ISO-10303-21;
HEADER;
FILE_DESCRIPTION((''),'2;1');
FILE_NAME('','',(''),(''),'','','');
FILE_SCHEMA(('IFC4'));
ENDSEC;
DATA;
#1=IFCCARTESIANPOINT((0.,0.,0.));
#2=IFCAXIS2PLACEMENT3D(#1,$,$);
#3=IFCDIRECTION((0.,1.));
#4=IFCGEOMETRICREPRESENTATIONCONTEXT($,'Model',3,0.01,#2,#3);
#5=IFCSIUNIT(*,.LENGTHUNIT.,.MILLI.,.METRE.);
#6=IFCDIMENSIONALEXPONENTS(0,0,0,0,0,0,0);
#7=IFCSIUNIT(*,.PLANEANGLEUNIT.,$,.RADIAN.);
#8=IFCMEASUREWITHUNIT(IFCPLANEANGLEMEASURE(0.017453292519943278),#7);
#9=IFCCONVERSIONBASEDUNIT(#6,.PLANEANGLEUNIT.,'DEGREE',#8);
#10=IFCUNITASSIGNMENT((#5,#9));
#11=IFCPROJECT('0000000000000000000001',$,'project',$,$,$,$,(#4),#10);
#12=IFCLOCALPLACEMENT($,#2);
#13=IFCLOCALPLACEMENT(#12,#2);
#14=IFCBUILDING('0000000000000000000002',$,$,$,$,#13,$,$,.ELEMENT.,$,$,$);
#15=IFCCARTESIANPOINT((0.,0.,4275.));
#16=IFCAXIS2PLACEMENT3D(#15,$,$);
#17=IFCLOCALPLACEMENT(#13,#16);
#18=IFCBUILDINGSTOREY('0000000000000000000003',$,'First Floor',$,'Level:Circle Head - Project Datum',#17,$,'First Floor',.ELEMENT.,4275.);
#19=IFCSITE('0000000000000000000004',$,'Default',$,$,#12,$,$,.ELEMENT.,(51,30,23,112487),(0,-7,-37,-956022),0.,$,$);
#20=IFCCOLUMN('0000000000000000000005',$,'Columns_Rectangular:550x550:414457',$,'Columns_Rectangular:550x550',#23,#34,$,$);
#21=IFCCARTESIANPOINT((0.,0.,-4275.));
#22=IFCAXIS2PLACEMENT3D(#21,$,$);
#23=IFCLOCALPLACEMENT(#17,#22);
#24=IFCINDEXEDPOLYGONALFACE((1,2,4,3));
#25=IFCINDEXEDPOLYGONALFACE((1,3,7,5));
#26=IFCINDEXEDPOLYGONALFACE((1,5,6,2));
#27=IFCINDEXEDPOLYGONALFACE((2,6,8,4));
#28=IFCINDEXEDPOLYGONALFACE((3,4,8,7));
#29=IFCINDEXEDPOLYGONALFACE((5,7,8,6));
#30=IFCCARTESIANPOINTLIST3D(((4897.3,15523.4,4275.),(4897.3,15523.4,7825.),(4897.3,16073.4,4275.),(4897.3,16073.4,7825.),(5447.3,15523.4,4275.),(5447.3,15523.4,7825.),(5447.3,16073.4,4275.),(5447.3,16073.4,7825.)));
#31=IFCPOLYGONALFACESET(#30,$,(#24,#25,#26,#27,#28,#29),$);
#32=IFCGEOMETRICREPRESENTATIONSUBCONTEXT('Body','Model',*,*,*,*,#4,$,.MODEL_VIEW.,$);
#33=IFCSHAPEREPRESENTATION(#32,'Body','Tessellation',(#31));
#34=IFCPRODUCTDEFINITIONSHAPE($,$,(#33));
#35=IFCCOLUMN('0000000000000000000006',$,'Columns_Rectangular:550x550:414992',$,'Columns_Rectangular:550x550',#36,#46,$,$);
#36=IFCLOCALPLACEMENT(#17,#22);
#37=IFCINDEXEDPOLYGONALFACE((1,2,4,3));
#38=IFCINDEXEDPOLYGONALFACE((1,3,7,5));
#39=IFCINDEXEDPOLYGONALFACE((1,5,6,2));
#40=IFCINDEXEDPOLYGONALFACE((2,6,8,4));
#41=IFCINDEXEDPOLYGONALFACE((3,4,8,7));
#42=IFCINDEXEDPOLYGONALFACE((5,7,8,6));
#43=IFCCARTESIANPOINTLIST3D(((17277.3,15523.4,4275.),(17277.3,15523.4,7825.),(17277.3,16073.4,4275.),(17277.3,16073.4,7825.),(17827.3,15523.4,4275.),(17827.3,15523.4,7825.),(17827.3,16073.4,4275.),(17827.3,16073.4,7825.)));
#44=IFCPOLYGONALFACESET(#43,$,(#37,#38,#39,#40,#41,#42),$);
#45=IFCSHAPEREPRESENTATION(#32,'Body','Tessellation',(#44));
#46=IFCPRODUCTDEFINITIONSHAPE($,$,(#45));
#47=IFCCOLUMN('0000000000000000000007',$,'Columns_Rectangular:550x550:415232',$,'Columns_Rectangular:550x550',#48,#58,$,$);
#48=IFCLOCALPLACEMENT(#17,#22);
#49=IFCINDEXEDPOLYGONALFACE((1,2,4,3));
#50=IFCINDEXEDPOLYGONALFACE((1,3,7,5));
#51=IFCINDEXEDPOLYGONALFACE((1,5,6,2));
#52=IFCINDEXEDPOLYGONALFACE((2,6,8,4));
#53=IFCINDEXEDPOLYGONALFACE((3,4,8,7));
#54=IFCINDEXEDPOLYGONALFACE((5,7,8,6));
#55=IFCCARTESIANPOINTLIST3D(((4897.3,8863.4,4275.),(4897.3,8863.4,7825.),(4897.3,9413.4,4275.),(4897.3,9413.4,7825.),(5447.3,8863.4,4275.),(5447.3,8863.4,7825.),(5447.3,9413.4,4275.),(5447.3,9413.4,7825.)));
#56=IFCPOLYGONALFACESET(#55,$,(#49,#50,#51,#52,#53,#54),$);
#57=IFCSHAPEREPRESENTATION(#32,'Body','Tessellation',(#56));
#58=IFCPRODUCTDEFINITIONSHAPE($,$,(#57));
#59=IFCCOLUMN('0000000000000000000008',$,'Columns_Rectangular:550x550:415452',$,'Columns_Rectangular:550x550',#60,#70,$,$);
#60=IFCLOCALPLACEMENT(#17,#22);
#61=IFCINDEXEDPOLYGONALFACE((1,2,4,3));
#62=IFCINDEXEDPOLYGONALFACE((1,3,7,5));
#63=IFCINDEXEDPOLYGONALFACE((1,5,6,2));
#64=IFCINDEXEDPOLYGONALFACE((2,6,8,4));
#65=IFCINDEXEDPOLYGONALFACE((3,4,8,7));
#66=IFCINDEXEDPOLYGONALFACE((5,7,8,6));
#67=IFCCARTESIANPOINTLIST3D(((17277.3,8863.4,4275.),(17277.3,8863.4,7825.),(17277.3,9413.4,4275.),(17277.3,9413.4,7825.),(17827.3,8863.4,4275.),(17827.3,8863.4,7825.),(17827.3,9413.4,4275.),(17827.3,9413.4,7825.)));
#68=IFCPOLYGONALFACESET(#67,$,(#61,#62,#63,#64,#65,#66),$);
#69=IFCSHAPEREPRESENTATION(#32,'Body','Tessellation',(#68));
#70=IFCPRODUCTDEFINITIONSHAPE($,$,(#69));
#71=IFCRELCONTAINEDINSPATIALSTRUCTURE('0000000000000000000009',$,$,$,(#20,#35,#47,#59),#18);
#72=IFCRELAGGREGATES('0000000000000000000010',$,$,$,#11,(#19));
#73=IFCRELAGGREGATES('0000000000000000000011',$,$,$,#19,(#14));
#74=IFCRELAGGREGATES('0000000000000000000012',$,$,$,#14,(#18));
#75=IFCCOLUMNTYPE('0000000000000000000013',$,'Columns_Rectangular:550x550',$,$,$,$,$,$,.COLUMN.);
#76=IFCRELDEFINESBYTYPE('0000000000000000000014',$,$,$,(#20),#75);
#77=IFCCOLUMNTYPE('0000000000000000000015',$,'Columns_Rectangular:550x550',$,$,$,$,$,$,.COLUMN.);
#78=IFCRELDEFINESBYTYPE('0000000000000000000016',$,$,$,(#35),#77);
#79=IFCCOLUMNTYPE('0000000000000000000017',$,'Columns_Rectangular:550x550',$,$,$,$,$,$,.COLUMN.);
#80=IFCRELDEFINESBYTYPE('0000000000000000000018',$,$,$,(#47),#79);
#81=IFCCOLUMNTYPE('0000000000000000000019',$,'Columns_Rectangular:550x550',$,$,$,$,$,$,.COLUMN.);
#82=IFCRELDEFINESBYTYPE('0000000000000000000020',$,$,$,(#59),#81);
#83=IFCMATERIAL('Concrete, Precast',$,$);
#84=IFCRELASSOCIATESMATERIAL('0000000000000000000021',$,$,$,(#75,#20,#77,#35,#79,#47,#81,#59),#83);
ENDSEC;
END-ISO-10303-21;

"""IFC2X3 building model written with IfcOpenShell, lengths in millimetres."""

from ifc_helpers import new_model, entity, si_unit, converted_unit, direction, frame, frame_2d, origin, place, context, subcontext, project, spatial, rectangle, extrude, source, transform, mapped, material, type_object, type_shapes, element, save


model = new_model("IFC2X3")

# Units and contexts
model_context = context("Model", 3, precision=0.01, world=origin(), true_north=direction((0.0, 1.0)))
body_context = subcontext(model_context, "Body", "Model", "MODEL_VIEW")
ifc_project = project(units=[si_unit("LENGTHUNIT", "METRE", prefix="MILLI"), converted_unit("PLANEANGLEUNIT", "DEGREE", entity("IfcPlaneAngleMeasure", 0.017453292519943278), si_unit("PLANEANGLEUNIT", "RADIAN"), dimensions=[0, 0, 0, 0, 0, 0, 0])], contexts=[model_context])

# Site, building, storey
site_placement = place(None, origin())
site = spatial("IfcSite", under=ifc_project, at=site_placement, Name="Default", CompositionType="ELEMENT", RefLatitude=(51, 30, 23, 112487), RefLongitude=(0, -7, -37, -956022), RefElevation=0.0)
building_placement = place(site_placement, origin())
building = spatial("IfcBuilding", under=site, at=building_placement, CompositionType="ELEMENT")
storey_placement = place(building_placement, frame((0.0, 0.0, 4275.0)))
storey = spatial("IfcBuildingStorey", under=building, at=storey_placement, Name="First Floor", ObjectType="Level:Circle Head - Project Datum", LongName="First Floor", CompositionType="ELEMENT", Elevation=4275.0)

# Columns
ifc_material_1 = material(Name="Concrete, Precast")
column_type_1 = type_object("IfcColumnType", Name="Columns_Rectangular:550x550", PredefinedType="COLUMN", material=ifc_material_1)
shared_shape_1 = source(origin(), body_context, "Body", "SweptSolid", [
    extrude(rectangle(XDim=550.0, YDim=550.0, at=frame_2d((0.0, 0.0), x_axis=(1.0, 0.0))), frame((5172.3, 15798.4, 4275.0), z_axis=(0.0, 0.0, 1.0), x_axis=(-1.0, 0.0, 0.0)), (0.0, 0.0, 1.0), 3550.0),
])
type_shapes(column_type_1, [shared_shape_1])
column_1_placement = place(storey_placement, frame((0.0, 0.0, -4275.0)))
element("IfcColumn", 1, at=column_1_placement, inside=storey, type_object=column_type_1, material=ifc_material_1, Name="Columns_Rectangular:550x550:414457", ObjectType="Columns_Rectangular:550x550", context=body_context, shape_type="MappedRepresentation", body=[
    mapped(shared_shape_1, transform((0.0, 0.0, 0.0), scale=1.0)),
])
column_type_2 = type_object("IfcColumnType", Name="Columns_Rectangular:550x550", PredefinedType="COLUMN", material=ifc_material_1)
shared_shape_2 = source(origin(), body_context, "Body", "SweptSolid", [
    extrude(rectangle(XDim=550.0, YDim=550.0, at=frame_2d((0.0, 0.0), x_axis=(1.0, 0.0))), frame((17552.3, 15798.4, 4275.0), z_axis=(0.0, 0.0, 1.0), x_axis=(-1.0, 0.0, 0.0)), (0.0, 0.0, 1.0), 3550.0),
])
type_shapes(column_type_2, [shared_shape_2])
column_2_placement = place(storey_placement, frame((0.0, 0.0, -4275.0)))
element("IfcColumn", 2, at=column_2_placement, inside=storey, type_object=column_type_2, material=ifc_material_1, Name="Columns_Rectangular:550x550:414992", ObjectType="Columns_Rectangular:550x550", context=body_context, shape_type="MappedRepresentation", body=[
    mapped(shared_shape_2, transform((0.0, 0.0, 0.0), scale=1.0)),
])
column_type_3 = type_object("IfcColumnType", Name="Columns_Rectangular:550x550", PredefinedType="COLUMN", material=ifc_material_1)
shared_shape_3 = source(origin(), body_context, "Body", "SweptSolid", [
    extrude(rectangle(XDim=550.0, YDim=550.0, at=frame_2d((0.0, 0.0), x_axis=(1.0, 0.0))), frame((5172.3, 9138.4, 4275.0), z_axis=(0.0, 0.0, 1.0), x_axis=(-1.0, 0.0, 0.0)), (0.0, 0.0, 1.0), 3550.0),
])
type_shapes(column_type_3, [shared_shape_3])
column_3_placement = place(storey_placement, frame((0.0, 0.0, -4275.0)))
element("IfcColumn", 3, at=column_3_placement, inside=storey, type_object=column_type_3, material=ifc_material_1, Name="Columns_Rectangular:550x550:415232", ObjectType="Columns_Rectangular:550x550", context=body_context, shape_type="MappedRepresentation", body=[
    mapped(shared_shape_3, transform((0.0, 0.0, 0.0), scale=1.0)),
])
column_type_4 = type_object("IfcColumnType", Name="Columns_Rectangular:550x550", PredefinedType="COLUMN", material=ifc_material_1)
shared_shape_4 = source(origin(), body_context, "Body", "SweptSolid", [
    extrude(rectangle(XDim=550.0, YDim=550.0, at=frame_2d((0.0, 0.0), x_axis=(1.0, 0.0))), frame((17552.3, 9138.4, 4275.0), z_axis=(0.0, 0.0, 1.0), x_axis=(-1.0, 0.0, 0.0)), (0.0, 0.0, 1.0), 3550.0),
])
type_shapes(column_type_4, [shared_shape_4])
column_4_placement = place(storey_placement, frame((0.0, 0.0, -4275.0)))
element("IfcColumn", 4, at=column_4_placement, inside=storey, type_object=column_type_4, material=ifc_material_1, Name="Columns_Rectangular:550x550:415452", ObjectType="Columns_Rectangular:550x550", context=body_context, shape_type="MappedRepresentation", body=[
    mapped(shared_shape_4, transform((0.0, 0.0, 0.0), scale=1.0)),
])

save(model, "model.ifc")
